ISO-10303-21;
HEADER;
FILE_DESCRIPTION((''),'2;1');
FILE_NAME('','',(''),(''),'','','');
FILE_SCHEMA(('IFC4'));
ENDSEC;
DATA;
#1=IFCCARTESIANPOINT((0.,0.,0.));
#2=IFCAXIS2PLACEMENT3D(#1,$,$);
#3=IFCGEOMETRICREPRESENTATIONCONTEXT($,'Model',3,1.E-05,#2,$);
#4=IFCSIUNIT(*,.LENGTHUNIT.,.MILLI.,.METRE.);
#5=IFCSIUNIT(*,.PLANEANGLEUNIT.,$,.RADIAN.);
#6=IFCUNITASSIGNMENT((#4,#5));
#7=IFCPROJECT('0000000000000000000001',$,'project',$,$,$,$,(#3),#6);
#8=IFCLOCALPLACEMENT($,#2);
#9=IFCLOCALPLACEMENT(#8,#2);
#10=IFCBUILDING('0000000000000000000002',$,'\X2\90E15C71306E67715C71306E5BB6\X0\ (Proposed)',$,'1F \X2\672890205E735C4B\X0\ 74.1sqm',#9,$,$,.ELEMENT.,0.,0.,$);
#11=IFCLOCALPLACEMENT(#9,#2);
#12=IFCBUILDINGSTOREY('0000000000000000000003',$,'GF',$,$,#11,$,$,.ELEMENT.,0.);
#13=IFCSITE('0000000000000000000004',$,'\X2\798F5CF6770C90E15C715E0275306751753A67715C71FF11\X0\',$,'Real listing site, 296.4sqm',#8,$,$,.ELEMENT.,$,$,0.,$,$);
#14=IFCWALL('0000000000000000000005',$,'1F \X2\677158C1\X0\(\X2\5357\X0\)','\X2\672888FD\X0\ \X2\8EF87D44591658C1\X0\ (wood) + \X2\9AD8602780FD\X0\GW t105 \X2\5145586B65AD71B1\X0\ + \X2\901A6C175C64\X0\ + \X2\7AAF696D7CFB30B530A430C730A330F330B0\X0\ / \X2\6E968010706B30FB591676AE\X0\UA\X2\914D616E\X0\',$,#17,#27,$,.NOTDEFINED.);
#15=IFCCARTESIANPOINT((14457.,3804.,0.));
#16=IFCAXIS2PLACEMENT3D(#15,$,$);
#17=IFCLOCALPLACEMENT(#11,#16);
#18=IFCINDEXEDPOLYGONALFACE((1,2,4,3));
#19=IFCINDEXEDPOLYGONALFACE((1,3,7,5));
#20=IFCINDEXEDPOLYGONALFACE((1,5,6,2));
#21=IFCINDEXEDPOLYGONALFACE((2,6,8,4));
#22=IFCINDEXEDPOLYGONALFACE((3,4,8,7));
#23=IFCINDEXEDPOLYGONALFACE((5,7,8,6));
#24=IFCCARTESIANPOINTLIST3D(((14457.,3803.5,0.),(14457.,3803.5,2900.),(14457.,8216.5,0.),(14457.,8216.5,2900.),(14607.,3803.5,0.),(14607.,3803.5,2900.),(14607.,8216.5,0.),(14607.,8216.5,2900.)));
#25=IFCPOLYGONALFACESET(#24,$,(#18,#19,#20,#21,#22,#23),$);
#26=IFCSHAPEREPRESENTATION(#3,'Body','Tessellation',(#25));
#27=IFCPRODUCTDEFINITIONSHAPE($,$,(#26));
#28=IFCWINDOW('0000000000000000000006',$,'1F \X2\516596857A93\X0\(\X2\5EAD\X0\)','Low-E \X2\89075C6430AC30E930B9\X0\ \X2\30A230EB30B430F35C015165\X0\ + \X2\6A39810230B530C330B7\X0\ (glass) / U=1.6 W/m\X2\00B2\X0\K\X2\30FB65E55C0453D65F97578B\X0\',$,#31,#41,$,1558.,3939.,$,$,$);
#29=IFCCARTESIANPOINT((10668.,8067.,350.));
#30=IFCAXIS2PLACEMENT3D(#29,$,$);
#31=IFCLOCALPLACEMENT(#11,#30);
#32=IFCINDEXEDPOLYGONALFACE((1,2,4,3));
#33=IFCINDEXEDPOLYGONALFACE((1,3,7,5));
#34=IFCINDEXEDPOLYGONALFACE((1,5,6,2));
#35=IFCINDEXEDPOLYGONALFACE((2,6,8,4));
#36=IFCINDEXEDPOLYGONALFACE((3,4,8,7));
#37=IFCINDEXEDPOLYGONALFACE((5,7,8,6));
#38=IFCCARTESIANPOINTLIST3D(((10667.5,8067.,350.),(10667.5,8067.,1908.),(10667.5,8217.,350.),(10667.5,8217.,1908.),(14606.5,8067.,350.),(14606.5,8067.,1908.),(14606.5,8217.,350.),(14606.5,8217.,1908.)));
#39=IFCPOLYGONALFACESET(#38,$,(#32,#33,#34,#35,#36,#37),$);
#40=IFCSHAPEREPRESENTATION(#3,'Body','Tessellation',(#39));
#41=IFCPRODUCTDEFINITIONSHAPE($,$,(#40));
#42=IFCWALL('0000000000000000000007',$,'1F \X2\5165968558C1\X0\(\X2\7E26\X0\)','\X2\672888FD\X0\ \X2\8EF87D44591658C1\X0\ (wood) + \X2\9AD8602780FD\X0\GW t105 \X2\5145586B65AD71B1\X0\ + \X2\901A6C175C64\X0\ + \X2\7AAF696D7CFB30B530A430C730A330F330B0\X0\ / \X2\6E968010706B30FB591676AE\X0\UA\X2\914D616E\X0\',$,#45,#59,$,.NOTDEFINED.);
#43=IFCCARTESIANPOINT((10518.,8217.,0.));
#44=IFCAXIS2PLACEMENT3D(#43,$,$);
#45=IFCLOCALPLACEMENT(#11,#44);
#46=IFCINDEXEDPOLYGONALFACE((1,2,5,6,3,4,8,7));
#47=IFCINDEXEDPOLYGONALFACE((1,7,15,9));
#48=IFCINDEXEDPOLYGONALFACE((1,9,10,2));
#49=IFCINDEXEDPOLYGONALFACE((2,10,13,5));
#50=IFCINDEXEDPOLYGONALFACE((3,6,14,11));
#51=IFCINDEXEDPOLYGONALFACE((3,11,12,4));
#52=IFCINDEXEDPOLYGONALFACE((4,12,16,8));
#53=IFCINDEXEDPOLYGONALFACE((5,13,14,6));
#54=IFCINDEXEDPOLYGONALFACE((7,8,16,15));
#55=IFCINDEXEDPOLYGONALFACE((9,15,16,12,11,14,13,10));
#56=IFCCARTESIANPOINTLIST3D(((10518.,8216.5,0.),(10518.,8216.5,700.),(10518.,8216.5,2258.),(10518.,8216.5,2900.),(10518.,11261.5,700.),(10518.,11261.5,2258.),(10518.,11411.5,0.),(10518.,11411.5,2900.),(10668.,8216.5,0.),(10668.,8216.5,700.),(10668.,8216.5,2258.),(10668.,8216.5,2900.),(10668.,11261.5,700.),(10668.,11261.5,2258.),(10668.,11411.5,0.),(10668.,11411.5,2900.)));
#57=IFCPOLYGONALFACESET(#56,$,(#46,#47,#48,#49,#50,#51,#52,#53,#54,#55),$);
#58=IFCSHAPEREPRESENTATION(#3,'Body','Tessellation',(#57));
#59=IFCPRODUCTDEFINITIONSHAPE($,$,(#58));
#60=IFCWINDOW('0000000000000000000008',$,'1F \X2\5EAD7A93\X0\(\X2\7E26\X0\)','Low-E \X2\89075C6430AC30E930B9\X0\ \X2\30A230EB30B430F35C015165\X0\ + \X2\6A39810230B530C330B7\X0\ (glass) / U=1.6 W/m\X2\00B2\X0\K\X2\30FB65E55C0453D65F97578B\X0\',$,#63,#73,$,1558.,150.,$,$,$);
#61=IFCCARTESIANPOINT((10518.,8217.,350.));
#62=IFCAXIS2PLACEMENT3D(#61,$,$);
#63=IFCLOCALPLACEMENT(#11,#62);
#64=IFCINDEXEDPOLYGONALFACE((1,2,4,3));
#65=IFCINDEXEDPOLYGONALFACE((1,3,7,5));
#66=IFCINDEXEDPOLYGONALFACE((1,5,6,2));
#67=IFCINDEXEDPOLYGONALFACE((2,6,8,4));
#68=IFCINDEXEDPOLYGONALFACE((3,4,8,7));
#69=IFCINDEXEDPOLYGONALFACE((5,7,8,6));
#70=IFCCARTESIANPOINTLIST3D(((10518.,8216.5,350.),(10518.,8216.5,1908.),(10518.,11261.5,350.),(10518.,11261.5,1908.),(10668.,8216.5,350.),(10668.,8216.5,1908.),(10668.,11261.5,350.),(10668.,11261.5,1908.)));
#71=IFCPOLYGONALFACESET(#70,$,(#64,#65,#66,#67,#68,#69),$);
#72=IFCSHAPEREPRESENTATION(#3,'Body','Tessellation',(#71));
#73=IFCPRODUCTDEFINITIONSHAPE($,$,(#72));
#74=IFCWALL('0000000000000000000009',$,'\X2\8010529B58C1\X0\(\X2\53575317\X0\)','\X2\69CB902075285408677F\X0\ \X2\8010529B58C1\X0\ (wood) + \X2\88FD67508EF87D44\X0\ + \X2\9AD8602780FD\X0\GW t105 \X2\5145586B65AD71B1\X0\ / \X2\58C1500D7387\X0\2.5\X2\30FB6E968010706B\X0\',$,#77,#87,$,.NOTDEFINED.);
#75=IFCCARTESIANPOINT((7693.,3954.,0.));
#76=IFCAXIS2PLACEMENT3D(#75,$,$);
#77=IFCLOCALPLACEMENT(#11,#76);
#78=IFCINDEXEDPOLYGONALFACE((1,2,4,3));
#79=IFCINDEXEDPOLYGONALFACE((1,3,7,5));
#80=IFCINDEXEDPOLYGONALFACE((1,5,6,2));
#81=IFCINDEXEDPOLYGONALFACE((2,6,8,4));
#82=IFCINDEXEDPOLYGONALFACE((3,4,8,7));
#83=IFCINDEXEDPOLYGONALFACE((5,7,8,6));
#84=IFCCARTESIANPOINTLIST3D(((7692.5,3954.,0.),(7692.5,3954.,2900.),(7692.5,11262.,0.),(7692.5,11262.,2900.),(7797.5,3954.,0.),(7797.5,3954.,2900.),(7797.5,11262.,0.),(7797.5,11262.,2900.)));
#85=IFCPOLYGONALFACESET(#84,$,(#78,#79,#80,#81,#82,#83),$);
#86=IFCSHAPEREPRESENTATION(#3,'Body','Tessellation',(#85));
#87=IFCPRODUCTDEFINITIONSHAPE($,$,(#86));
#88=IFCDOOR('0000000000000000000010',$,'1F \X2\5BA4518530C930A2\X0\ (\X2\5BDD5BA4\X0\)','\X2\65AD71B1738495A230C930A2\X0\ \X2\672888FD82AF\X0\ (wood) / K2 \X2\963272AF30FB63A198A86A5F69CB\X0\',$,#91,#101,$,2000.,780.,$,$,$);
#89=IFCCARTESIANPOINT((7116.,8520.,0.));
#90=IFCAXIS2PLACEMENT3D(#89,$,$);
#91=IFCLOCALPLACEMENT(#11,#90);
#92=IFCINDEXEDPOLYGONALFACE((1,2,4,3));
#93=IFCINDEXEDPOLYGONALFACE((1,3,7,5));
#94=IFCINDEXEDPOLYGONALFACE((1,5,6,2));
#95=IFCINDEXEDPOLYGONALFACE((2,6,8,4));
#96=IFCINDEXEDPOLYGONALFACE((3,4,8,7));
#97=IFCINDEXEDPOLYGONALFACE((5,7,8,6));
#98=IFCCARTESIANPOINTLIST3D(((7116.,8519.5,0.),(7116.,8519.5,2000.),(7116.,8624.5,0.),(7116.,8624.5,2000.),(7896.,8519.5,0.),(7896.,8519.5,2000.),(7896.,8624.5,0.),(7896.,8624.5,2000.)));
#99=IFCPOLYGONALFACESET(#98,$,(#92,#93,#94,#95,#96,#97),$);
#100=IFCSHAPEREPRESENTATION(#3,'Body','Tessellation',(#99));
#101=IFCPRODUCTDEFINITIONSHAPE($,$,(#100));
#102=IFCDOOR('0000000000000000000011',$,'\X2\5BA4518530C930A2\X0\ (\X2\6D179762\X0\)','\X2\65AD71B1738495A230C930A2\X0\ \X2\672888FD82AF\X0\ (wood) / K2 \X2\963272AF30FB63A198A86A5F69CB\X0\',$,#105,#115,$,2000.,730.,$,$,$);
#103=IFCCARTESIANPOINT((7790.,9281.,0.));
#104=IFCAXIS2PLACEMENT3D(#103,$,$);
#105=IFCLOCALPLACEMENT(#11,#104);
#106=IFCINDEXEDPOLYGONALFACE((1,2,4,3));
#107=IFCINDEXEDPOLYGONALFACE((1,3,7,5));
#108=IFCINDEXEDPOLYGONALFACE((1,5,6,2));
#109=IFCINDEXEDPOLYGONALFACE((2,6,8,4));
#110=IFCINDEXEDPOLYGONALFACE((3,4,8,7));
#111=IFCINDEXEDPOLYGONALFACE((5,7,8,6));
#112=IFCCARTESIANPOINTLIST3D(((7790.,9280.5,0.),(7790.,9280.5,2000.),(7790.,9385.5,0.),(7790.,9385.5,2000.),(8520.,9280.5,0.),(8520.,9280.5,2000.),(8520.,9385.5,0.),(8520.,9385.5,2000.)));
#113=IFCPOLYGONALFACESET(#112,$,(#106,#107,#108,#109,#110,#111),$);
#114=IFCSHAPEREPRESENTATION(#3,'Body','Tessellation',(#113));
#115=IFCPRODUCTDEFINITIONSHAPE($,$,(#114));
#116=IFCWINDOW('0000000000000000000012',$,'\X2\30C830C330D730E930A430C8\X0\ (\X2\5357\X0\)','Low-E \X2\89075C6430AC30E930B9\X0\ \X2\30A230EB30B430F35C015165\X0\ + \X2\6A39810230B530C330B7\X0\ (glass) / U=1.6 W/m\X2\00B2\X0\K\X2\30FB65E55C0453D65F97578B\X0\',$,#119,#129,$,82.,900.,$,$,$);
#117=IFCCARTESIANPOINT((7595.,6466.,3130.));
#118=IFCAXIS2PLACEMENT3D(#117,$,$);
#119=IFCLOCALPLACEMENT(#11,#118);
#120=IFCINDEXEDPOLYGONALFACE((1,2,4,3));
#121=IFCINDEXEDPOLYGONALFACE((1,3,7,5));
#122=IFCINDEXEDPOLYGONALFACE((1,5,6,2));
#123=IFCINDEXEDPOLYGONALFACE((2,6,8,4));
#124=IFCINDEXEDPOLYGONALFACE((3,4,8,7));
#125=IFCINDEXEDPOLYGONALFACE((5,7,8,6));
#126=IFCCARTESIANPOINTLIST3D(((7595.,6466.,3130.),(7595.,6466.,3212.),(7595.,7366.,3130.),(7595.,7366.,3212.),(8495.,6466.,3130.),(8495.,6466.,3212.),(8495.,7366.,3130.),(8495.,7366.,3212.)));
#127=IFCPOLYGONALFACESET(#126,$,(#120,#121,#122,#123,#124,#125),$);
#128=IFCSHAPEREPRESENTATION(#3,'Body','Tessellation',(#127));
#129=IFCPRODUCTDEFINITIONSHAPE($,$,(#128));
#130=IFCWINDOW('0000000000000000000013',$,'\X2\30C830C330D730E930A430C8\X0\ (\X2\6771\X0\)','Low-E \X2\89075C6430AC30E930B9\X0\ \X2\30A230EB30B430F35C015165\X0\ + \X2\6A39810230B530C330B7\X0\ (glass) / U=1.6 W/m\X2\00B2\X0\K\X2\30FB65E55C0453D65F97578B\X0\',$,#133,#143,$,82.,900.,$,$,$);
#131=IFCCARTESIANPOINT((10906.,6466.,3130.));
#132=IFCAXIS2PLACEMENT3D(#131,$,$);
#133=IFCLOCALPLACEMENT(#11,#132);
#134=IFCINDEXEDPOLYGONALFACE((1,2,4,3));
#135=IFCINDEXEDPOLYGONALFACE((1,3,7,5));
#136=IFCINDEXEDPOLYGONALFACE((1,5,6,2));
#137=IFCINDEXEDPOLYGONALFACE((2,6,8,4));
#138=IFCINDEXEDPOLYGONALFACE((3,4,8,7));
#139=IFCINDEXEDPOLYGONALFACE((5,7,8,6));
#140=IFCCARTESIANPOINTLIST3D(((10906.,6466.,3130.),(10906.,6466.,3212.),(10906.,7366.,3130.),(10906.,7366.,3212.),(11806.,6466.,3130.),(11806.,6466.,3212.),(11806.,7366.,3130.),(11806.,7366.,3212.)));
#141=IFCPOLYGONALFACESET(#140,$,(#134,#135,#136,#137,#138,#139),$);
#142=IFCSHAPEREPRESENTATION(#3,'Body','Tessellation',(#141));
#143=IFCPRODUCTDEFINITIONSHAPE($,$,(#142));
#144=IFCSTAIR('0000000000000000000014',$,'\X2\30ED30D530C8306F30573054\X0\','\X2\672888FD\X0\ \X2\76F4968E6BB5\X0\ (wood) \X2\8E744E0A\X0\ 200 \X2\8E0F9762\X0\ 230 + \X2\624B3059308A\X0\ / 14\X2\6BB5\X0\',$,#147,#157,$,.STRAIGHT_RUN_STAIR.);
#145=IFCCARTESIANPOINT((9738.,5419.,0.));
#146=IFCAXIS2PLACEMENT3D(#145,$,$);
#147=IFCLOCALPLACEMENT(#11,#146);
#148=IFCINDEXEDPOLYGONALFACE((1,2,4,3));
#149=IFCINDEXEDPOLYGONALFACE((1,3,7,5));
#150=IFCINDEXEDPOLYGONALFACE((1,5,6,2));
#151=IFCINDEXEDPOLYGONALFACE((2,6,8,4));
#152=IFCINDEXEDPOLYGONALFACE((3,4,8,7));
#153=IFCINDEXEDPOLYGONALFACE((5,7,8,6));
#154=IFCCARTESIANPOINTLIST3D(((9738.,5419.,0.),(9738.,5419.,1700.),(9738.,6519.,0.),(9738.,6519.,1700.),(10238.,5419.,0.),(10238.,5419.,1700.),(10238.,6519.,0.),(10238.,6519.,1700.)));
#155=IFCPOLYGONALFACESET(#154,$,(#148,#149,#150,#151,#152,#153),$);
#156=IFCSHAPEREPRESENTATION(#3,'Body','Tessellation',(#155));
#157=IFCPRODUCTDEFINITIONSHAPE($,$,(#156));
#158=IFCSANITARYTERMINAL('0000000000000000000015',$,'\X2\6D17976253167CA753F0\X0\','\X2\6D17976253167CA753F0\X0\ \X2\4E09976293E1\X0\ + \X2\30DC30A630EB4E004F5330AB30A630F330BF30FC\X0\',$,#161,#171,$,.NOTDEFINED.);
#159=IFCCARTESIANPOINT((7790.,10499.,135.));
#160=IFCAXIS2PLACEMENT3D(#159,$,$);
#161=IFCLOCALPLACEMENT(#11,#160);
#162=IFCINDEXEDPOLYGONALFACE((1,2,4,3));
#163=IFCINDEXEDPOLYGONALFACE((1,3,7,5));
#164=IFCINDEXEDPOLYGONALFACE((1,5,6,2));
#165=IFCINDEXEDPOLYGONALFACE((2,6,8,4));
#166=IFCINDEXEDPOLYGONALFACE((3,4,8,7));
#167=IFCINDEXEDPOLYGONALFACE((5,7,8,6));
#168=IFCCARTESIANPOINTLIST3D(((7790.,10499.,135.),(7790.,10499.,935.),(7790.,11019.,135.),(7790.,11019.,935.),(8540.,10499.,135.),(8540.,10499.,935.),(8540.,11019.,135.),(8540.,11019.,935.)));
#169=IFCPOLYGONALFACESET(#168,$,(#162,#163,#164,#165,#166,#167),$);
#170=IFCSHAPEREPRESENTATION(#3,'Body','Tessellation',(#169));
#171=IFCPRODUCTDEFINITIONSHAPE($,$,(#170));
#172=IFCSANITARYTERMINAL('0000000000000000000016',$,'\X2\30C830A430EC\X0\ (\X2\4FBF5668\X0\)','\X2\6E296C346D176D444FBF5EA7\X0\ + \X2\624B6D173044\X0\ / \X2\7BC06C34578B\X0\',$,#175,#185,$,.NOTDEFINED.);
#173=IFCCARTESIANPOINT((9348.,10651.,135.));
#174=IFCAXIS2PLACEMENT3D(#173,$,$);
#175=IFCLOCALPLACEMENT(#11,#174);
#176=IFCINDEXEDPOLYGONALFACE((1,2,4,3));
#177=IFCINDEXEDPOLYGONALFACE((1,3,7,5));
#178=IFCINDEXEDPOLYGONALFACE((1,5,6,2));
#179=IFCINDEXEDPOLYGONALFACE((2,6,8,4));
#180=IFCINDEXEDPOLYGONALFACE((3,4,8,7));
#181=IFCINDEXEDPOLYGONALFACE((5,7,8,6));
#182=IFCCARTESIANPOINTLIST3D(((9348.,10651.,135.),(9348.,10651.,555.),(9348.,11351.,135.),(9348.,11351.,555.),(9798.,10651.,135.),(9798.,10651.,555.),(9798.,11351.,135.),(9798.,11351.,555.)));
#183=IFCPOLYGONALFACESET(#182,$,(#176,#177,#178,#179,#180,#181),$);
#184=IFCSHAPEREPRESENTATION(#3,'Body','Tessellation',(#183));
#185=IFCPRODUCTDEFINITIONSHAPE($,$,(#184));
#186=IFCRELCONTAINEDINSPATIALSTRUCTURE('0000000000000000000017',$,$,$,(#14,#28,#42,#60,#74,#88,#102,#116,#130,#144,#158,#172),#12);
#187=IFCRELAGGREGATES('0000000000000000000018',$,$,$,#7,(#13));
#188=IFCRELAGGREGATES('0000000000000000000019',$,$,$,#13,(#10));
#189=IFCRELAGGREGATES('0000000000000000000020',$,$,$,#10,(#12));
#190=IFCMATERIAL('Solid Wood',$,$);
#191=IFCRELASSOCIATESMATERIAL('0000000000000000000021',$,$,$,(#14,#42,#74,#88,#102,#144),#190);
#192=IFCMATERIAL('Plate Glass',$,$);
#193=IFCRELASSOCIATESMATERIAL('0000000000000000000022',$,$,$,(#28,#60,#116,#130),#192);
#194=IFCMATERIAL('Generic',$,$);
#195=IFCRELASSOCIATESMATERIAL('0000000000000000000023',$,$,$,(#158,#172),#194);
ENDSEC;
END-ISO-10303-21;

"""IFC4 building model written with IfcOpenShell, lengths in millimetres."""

from ifc_helpers import new_model, si_unit, frame, frame_2d, origin, place, context, project, spatial, rectangle, extrude, material, element, fill, save


model = new_model("IFC4")

# Units and contexts
model_context = context("Model", 3, precision=1e-05, world=origin())
ifc_project = project(units=[si_unit("LENGTHUNIT", "METRE", prefix="MILLI"), si_unit("PLANEANGLEUNIT", "RADIAN")], contexts=[model_context])

# Site, building, storey
site_placement = place(None, origin())
site = spatial("IfcSite", under=ifc_project, at=site_placement, Name="福島県郡山市田村町東山１", ObjectType="Real listing site, 296.4sqm", CompositionType="ELEMENT", RefElevation=0.0)
building_placement = place(site_placement, origin())
building = spatial("IfcBuilding", under=site, at=building_placement, Name="郡山の東山の家 (Proposed)", ObjectType="1F 木造平屋 74.1sqm", CompositionType="ELEMENT", ElevationOfRefHeight=0.0, ElevationOfTerrain=0.0)
storey_placement = place(building_placement, origin())
storey = spatial("IfcBuildingStorey", under=building, at=storey_placement, Name="GF", CompositionType="ELEMENT", Elevation=0.0)

# Shared definitions
ifc_material_1 = material(Name="Solid Wood")

# Wall, opening, window
wall_1_placement = place(storey_placement, frame((14457.0, 3804.0, 0.0)))
wall_1 = element("IfcWall", 1, at=wall_1_placement, inside=storey, material=ifc_material_1, Name="1F 東壁(南)", Description="木製 軸組外壁 (wood) + 高性能GW t105 充填断熱 + 通気層 + 窯業系サイディング / 準耐火・外皮UA配慮", PredefinedType="NOTDEFINED", context=model_context, shape_type="SweptSolid", body=[
    extrude(rectangle(XDim=150.0, YDim=4413.0, at=frame_2d((75.0, 2206.0))), frame((14457.0, 3804.0, 0.0)), (0.0, 0.0, 1.0), 2900.0),
])
opening_1_placement = place(storey_placement, frame((10668.0, 8067.0, 350.0)))
opening_1 = element("IfcOpeningElement", 2, at=opening_1_placement, cuts=wall_1, PredefinedType="NOTDEFINED", context=model_context, shape_type="SweptSolid", body=[
    extrude(rectangle(XDim=3939.0, YDim=150.0, at=frame_2d((1969.0, 75.0))), frame((10668.0, 8067.0, 350.0)), (0.0, 0.0, 1.0), 1558.0),
])
ifc_material_2 = material(Name="Plate Glass")
window_1_placement = place(storey_placement, frame((10668.0, 8067.0, 350.0)))
window_1 = element("IfcWindow", 3, at=window_1_placement, inside=storey, material=ifc_material_2, Name="1F 入隅窓(庭)", Description="Low-E 複層ガラス アルゴン封入 + 樹脂サッシ (glass) / U=1.6 W/m²K・日射取得型", OverallHeight=1558.0, OverallWidth=3939.0, context=model_context, shape_type="SweptSolid", body=[
    extrude(rectangle(XDim=3939.0, YDim=150.0, at=frame_2d((1969.0, 75.0))), frame((10668.0, 8067.0, 350.0)), (0.0, 0.0, 1.0), 1558.0),
])
fill(opening_1, window_1)

# Wall, opening, window
wall_2_placement = place(storey_placement, frame((10518.0, 8217.0, 0.0)))
wall_2 = element("IfcWall", 4, at=wall_2_placement, inside=storey, material=ifc_material_1, Name="1F 入隅壁(縦)", Description="木製 軸組外壁 (wood) + 高性能GW t105 充填断熱 + 通気層 + 窯業系サイディング / 準耐火・外皮UA配慮", PredefinedType="NOTDEFINED", context=model_context, shape_type="SweptSolid", body=[
    extrude(rectangle(XDim=150.0, YDim=3195.0, at=frame_2d((75.0, 1597.0))), frame((10518.0, 8217.0, 0.0)), (0.0, 0.0, 1.0), 2900.0),
])
opening_2_placement = place(storey_placement, frame((10518.0, 8217.0, 350.0)))
opening_2 = element("IfcOpeningElement", 5, at=opening_2_placement, cuts=wall_2, PredefinedType="NOTDEFINED", context=model_context, shape_type="SweptSolid", body=[
    extrude(rectangle(XDim=150.0, YDim=3045.0, at=frame_2d((75.0, 1522.0))), frame((10518.0, 8217.0, 350.0)), (0.0, 0.0, 1.0), 1558.0),
])
window_2_placement = place(storey_placement, frame((10518.0, 8217.0, 350.0)))
window_2 = element("IfcWindow", 6, at=window_2_placement, inside=storey, material=ifc_material_2, Name="1F 庭窓(縦)", Description="Low-E 複層ガラス アルゴン封入 + 樹脂サッシ (glass) / U=1.6 W/m²K・日射取得型", OverallHeight=1558.0, OverallWidth=150.0, context=model_context, shape_type="SweptSolid", body=[
    extrude(rectangle(XDim=150.0, YDim=3045.0, at=frame_2d((75.0, 1522.0))), frame((10518.0, 8217.0, 350.0)), (0.0, 0.0, 1.0), 1558.0),
])
fill(opening_2, window_2)

# Wall, openings, doors
wall_3_placement = place(storey_placement, frame((7693.0, 3954.0, 0.0)))
wall_3 = element("IfcWall", 7, at=wall_3_placement, inside=storey, material=ifc_material_1, Name="耐力壁(南北)", Description="構造用合板 耐力壁 (wood) + 製材軸組 + 高性能GW t105 充填断熱 / 壁倍率2.5・準耐火", PredefinedType="NOTDEFINED", context=model_context, shape_type="SweptSolid", body=[
    extrude(rectangle(XDim=105.0, YDim=7308.0, at=frame_2d((52.0, 3654.0))), frame((7693.0, 3954.0, 0.0)), (0.0, 0.0, 1.0), 2900.0),
])
opening_3_placement = place(storey_placement, frame((7116.0, 8520.0, 0.0)))
opening_3 = element("IfcOpeningElement", 8, at=opening_3_placement, cuts=wall_3, PredefinedType="NOTDEFINED", context=model_context, shape_type="SweptSolid", body=[
    extrude(rectangle(XDim=780.0, YDim=105.0, at=frame_2d((390.0, 52.0))), frame((7116.0, 8520.0, 0.0)), (0.0, 0.0, 1.0), 2000.0),
])
opening_4_placement = place(storey_placement, frame((7790.0, 9281.0, 0.0)))
opening_4 = element("IfcOpeningElement", 9, at=opening_4_placement, cuts=wall_3, PredefinedType="NOTDEFINED", context=model_context, shape_type="SweptSolid", body=[
    extrude(rectangle(XDim=730.0, YDim=105.0, at=frame_2d((365.0, 52.0))), frame((7790.0, 9281.0, 0.0)), (0.0, 0.0, 1.0), 2000.0),
])
door_1_placement = place(storey_placement, frame((7116.0, 8520.0, 0.0)))
door_1 = element("IfcDoor", 10, at=door_1_placement, inside=storey, material=ifc_material_1, Name="1F 室内ドア (寝室)", Description="断熱玄関ドア 木製芯 (wood) / K2 防犯・採風機構", OverallHeight=2000.0, OverallWidth=780.0, context=model_context, shape_type="SweptSolid", body=[
    extrude(rectangle(XDim=780.0, YDim=105.0, at=frame_2d((390.0, 52.0))), frame((7116.0, 8520.0, 0.0)), (0.0, 0.0, 1.0), 2000.0),
])
fill(opening_3, door_1)
door_2_placement = place(storey_placement, frame((7790.0, 9281.0, 0.0)))
door_2 = element("IfcDoor", 11, at=door_2_placement, inside=storey, material=ifc_material_1, Name="室内ドア (洗面)", Description="断熱玄関ドア 木製芯 (wood) / K2 防犯・採風機構", OverallHeight=2000.0, OverallWidth=730.0, context=model_context, shape_type="SweptSolid", body=[
    extrude(rectangle(XDim=730.0, YDim=105.0, at=frame_2d((365.0, 52.0))), frame((7790.0, 9281.0, 0.0)), (0.0, 0.0, 1.0), 2000.0),
])
fill(opening_4, door_2)

# Windows
window_3_placement = place(storey_placement, frame((7595.0, 6466.0, 3130.0)))
element("IfcWindow", 12, at=window_3_placement, inside=storey, material=ifc_material_2, Name="トップライト (南)", Description="Low-E 複層ガラス アルゴン封入 + 樹脂サッシ (glass) / U=1.6 W/m²K・日射取得型", OverallHeight=82.0, OverallWidth=900.0, context=model_context, shape_type="SweptSolid", body=[
    extrude(rectangle(XDim=900.0, YDim=900.0, at=frame_2d((450.0, 450.0))), frame((7595.0, 6466.0, 3130.0)), (0.0, 0.0, 1.0), 82.0),
])
window_4_placement = place(storey_placement, frame((10906.0, 6466.0, 3130.0)))
element("IfcWindow", 13, at=window_4_placement, inside=storey, material=ifc_material_2, Name="トップライト (東)", Description="Low-E 複層ガラス アルゴン封入 + 樹脂サッシ (glass) / U=1.6 W/m²K・日射取得型", OverallHeight=82.0, OverallWidth=900.0, context=model_context, shape_type="SweptSolid", body=[
    extrude(rectangle(XDim=900.0, YDim=900.0, at=frame_2d((450.0, 450.0))), frame((10906.0, 6466.0, 3130.0)), (0.0, 0.0, 1.0), 82.0),
])

# Stair
stair_placement = place(storey_placement, frame((9738.0, 5419.0, 0.0)))
element("IfcStair", 14, at=stair_placement, inside=storey, material=ifc_material_1, Name="ロフトはしご", Description="木製 直階段 (wood) 蹴上 200 踏面 230 + 手すり / 14段", PredefinedType="STRAIGHT_RUN_STAIR", context=model_context, shape_type="SweptSolid", body=[
    extrude(rectangle(XDim=500.0, YDim=1100.0, at=frame_2d((250.0, 550.0))), frame((9738.0, 5419.0, 0.0)), (0.0, 0.0, 1.0), 1700.0),
])

# Sanitary terminals
ifc_material_3 = material(Name="Generic")
sanitary_terminal_1_placement = place(storey_placement, frame((7790.0, 10499.0, 135.0)))
element("IfcSanitaryTerminal", 15, at=sanitary_terminal_1_placement, inside=storey, material=ifc_material_3, Name="洗面化粧台", Description="洗面化粧台 三面鏡 + ボウル一体カウンター", PredefinedType="NOTDEFINED", context=model_context, shape_type="SweptSolid", body=[
    extrude(rectangle(XDim=750.0, YDim=520.0, at=frame_2d((375.0, 260.0))), frame((7790.0, 10499.0, 135.0)), (0.0, 0.0, 1.0), 800.0),
])
sanitary_terminal_2_placement = place(storey_placement, frame((9348.0, 10651.0, 135.0)))
element("IfcSanitaryTerminal", 16, at=sanitary_terminal_2_placement, inside=storey, material=ifc_material_3, Name="トイレ (便器)", Description="温水洗浄便座 + 手洗い / 節水型", PredefinedType="NOTDEFINED", context=model_context, shape_type="SweptSolid", body=[
    extrude(rectangle(XDim=450.0, YDim=700.0, at=frame_2d((225.0, 350.0))), frame((9348.0, 10651.0, 135.0)), (0.0, 0.0, 1.0), 420.0),
])

save(model, "model.ifc")
